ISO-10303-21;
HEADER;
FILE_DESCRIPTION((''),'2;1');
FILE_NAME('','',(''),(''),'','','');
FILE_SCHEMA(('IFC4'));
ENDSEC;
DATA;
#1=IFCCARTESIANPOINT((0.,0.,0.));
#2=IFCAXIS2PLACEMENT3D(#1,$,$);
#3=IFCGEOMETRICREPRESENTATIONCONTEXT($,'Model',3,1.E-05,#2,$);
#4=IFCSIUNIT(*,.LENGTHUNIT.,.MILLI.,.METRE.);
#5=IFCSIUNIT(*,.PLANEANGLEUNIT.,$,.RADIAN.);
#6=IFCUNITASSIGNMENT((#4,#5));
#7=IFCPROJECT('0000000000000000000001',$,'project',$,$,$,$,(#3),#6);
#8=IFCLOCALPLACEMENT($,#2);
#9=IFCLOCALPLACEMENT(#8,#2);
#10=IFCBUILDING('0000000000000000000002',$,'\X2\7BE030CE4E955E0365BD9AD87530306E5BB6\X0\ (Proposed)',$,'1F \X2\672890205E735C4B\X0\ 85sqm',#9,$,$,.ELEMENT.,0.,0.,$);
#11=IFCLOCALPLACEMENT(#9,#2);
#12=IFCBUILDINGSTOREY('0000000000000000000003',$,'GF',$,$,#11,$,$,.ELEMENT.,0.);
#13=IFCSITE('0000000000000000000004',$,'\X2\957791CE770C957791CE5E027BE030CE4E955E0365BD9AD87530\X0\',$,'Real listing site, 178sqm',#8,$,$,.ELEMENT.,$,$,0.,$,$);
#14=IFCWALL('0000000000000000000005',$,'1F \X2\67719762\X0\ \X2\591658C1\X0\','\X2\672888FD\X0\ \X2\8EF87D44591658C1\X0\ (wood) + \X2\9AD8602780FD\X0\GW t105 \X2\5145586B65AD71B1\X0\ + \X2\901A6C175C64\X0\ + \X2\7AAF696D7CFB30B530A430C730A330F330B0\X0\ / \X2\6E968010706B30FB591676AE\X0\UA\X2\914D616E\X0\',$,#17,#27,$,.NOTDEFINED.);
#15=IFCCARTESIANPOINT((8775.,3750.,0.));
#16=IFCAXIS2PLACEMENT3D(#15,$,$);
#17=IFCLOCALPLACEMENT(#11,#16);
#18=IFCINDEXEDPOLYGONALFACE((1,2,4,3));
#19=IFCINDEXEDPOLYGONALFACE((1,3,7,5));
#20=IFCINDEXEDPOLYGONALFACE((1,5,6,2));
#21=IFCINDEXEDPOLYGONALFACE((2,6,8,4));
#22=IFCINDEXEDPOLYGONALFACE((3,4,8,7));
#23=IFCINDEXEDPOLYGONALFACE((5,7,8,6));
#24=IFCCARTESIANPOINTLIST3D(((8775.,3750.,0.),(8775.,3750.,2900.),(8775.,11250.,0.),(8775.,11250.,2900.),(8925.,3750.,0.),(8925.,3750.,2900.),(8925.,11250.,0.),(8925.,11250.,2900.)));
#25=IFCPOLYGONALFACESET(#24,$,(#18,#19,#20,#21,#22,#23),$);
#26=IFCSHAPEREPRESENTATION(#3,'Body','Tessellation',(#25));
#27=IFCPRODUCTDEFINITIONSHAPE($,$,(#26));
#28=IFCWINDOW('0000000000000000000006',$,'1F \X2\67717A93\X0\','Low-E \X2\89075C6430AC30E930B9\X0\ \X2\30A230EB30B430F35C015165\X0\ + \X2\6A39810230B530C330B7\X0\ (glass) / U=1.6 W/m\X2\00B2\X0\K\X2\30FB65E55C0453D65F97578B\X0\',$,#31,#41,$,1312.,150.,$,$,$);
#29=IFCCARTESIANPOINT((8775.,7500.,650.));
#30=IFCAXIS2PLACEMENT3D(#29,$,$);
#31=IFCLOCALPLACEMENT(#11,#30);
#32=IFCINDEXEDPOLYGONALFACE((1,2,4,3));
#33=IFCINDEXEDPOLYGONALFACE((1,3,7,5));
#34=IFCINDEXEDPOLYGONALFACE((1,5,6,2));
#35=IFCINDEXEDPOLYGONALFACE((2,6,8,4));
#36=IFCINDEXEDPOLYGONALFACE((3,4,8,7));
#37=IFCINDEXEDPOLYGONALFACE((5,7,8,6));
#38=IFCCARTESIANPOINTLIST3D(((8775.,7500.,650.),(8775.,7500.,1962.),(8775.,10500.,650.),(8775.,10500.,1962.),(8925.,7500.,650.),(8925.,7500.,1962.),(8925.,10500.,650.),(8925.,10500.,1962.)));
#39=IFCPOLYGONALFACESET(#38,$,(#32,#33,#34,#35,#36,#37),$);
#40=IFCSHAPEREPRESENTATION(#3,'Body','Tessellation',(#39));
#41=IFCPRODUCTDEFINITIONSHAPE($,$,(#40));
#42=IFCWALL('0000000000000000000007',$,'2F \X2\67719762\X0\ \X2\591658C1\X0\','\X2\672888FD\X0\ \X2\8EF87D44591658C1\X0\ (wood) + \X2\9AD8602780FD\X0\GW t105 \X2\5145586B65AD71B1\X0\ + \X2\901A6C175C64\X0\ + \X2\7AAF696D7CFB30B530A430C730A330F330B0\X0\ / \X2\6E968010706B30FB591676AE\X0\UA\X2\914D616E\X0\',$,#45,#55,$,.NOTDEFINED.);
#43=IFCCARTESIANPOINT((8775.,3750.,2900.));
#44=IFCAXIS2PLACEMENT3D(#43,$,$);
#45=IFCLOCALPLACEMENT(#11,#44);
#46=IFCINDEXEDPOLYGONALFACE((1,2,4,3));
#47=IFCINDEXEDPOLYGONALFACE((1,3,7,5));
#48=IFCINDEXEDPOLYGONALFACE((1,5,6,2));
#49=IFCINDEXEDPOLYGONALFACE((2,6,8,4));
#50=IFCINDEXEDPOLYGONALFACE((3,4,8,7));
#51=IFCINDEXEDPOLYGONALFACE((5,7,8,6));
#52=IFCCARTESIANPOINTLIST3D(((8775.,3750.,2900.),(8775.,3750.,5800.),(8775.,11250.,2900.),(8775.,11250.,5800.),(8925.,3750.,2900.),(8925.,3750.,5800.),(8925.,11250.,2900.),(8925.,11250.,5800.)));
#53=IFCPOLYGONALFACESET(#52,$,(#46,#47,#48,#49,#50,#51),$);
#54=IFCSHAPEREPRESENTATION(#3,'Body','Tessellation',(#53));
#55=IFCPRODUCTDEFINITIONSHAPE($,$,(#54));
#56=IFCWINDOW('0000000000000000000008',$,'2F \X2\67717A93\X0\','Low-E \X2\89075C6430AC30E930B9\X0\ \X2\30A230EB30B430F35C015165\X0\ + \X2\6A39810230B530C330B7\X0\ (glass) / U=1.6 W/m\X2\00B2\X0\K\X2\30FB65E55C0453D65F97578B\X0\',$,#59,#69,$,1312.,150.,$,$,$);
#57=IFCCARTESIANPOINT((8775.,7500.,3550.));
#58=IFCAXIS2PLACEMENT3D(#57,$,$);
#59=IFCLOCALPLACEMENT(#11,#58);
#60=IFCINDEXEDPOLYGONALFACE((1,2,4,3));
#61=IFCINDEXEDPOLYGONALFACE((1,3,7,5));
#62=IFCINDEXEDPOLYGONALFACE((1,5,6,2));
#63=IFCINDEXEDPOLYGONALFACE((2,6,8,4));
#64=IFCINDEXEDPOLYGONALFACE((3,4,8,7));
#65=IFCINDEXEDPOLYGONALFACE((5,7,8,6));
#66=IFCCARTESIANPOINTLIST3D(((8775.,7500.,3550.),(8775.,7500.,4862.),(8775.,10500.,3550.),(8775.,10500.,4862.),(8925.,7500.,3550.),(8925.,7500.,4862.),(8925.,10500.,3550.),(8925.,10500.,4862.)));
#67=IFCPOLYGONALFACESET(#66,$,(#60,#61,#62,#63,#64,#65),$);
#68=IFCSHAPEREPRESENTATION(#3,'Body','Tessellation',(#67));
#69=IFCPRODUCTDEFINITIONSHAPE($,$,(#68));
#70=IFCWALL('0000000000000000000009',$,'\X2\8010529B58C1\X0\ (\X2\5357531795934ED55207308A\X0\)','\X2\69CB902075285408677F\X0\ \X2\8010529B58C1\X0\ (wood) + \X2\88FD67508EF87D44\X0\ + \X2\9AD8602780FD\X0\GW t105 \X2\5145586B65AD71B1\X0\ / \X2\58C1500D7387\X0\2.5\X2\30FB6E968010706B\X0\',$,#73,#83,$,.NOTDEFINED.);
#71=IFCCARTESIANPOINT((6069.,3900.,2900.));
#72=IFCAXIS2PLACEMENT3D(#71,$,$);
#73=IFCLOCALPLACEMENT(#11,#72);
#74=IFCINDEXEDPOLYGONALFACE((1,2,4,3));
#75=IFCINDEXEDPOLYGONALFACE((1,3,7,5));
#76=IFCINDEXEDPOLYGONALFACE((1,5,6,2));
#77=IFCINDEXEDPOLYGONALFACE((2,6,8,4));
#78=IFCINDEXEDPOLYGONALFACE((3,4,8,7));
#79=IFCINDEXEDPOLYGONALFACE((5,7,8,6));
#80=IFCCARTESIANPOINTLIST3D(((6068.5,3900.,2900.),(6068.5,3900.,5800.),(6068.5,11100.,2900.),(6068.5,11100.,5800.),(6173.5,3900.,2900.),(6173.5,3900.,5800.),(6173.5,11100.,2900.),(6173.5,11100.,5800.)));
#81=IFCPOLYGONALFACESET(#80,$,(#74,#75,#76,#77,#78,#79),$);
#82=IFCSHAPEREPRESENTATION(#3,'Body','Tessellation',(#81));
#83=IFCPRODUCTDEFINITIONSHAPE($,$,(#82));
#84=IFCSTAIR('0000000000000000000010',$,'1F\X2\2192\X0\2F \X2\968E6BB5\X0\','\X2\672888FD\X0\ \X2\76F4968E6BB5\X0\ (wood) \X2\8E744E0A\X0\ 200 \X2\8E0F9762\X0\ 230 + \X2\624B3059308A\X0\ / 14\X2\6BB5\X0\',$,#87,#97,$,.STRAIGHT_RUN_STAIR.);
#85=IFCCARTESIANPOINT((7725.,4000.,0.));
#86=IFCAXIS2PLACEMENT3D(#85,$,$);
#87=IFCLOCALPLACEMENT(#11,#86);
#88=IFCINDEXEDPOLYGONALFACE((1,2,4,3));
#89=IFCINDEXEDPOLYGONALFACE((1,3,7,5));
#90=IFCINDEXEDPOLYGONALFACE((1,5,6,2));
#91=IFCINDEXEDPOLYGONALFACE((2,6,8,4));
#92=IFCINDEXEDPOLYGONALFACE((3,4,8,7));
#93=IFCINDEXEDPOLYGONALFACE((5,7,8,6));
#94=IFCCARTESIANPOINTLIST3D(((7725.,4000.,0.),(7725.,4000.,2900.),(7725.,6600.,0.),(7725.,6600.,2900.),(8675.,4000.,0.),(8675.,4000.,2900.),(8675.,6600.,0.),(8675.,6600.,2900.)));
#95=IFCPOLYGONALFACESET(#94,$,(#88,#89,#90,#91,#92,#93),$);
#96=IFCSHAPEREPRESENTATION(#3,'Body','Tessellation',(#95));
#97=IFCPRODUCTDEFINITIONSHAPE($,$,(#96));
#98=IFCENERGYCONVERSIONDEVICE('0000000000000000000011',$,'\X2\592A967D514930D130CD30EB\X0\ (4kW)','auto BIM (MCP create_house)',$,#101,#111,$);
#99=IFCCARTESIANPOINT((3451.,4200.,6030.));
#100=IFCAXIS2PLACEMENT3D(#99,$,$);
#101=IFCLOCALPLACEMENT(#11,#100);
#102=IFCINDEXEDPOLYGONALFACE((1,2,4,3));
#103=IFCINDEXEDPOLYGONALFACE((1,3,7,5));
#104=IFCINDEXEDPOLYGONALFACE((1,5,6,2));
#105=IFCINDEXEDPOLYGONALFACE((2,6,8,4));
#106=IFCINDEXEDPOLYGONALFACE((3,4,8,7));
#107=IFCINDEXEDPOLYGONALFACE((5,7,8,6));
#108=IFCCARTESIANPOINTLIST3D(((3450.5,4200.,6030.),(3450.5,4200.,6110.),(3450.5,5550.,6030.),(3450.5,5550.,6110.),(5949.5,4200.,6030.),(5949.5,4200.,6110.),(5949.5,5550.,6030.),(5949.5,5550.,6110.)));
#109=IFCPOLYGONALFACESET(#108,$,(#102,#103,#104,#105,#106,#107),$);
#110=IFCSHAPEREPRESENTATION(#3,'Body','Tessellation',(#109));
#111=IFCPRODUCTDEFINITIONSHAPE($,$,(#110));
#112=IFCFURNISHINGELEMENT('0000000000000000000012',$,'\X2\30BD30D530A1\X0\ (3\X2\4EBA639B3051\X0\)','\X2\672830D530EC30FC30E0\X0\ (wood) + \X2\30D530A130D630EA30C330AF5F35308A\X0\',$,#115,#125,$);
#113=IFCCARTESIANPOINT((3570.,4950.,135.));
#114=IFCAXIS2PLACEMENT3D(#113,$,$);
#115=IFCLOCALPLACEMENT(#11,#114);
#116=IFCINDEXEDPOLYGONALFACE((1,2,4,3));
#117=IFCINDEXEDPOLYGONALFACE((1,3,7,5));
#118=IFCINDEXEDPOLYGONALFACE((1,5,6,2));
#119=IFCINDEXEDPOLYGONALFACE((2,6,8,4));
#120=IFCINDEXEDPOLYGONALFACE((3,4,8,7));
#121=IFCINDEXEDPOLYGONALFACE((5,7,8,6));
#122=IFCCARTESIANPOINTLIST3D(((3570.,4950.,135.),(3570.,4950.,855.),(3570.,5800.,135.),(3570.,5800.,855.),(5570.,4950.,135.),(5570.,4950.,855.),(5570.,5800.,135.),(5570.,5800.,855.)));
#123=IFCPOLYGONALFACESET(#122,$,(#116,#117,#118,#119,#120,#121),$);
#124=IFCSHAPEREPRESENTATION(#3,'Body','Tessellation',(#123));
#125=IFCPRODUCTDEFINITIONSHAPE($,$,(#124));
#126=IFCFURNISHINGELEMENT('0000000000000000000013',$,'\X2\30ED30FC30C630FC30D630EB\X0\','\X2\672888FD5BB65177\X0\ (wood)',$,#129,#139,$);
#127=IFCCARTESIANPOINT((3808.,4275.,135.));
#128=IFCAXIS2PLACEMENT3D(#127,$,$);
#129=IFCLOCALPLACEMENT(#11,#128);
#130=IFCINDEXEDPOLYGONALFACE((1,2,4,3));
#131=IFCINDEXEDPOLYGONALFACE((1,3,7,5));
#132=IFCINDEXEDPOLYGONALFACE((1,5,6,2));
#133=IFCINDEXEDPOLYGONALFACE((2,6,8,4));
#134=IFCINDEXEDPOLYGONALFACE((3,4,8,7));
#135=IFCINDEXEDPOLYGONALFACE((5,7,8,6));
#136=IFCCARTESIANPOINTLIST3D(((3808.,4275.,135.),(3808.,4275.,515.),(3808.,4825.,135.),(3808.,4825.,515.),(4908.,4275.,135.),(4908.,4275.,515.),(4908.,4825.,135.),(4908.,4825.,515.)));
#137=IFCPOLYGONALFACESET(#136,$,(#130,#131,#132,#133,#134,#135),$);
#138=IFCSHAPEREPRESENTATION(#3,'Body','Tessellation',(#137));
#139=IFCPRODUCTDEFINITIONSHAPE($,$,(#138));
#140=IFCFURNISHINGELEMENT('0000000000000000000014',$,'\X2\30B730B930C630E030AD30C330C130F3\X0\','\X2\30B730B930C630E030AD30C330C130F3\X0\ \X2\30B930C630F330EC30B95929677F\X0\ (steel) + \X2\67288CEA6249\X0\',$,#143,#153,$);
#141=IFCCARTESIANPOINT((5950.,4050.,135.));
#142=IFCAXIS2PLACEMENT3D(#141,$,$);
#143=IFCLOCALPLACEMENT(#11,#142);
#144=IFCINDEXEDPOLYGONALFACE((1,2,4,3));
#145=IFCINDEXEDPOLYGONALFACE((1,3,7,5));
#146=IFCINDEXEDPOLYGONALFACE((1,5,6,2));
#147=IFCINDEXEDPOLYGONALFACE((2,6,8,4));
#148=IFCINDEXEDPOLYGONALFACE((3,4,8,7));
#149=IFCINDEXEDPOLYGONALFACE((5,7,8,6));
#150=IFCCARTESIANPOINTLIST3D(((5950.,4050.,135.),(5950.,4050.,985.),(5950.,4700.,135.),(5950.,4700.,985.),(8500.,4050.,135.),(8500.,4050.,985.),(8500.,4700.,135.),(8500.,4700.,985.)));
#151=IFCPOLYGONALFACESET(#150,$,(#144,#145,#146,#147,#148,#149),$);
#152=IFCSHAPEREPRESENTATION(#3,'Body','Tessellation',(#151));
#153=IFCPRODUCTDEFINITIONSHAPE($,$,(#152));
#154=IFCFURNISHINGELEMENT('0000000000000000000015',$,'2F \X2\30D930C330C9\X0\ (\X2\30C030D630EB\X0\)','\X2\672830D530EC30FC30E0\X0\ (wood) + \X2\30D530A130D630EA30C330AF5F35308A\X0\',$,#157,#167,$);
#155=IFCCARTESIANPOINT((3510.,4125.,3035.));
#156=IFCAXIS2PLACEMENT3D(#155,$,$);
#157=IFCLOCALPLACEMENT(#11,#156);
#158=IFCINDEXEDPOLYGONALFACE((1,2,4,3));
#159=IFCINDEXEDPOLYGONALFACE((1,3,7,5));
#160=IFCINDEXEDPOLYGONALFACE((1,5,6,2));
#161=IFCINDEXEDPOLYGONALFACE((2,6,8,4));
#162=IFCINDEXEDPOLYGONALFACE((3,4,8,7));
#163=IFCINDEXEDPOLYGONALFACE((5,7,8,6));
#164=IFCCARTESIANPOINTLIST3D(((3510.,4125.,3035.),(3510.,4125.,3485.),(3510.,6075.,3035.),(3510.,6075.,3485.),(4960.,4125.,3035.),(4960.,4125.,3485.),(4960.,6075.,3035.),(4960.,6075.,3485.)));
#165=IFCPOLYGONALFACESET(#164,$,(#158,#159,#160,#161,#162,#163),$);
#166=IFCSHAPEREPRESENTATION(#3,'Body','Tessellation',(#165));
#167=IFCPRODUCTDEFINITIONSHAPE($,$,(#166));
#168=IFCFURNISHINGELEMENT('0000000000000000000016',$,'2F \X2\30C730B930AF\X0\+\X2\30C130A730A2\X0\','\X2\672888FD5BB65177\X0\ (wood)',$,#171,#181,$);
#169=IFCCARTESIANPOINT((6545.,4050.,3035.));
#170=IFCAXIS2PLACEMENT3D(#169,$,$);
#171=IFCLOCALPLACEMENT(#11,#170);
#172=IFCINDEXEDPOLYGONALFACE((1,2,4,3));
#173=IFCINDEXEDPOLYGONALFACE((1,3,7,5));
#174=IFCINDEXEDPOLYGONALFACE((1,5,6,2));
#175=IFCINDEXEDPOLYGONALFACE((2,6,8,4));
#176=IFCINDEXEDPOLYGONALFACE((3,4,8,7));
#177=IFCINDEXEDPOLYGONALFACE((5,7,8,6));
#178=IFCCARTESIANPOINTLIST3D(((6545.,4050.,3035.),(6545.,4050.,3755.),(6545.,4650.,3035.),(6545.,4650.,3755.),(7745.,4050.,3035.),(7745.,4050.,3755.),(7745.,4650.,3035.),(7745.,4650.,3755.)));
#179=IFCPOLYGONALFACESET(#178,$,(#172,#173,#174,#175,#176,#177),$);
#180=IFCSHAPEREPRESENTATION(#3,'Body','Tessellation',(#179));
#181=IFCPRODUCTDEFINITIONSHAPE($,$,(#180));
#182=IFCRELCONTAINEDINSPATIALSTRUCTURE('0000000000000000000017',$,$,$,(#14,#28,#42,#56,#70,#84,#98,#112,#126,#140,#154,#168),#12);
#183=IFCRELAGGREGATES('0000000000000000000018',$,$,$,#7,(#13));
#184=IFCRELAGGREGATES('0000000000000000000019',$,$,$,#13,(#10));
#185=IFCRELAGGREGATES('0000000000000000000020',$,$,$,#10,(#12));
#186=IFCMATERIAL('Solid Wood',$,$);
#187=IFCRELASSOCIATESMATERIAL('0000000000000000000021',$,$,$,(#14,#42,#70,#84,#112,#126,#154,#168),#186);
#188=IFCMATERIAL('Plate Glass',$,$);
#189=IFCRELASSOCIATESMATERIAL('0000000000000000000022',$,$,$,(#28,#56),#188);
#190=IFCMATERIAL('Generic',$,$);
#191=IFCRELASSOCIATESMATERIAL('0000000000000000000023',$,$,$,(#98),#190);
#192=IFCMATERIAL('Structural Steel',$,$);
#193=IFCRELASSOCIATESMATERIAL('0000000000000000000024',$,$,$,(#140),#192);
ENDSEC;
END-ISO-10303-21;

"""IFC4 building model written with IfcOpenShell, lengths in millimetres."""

from ifc_helpers import new_model, si_unit, frame, frame_2d, origin, place, context, project, spatial, rectangle, extrude, material, element, fill, save


model = new_model("IFC4")

# Units and contexts
model_context = context("Model", 3, precision=1e-05, world=origin())
ifc_project = project(units=[si_unit("LENGTHUNIT", "METRE", prefix="MILLI"), si_unit("PLANEANGLEUNIT", "RADIAN")], contexts=[model_context])

# Site, building, storey
site_placement = place(None, origin())
site = spatial("IfcSite", under=ifc_project, at=site_placement, Name="長野県長野市篠ノ井布施高田", ObjectType="Real listing site, 178sqm", CompositionType="ELEMENT", RefElevation=0.0)
building_placement = place(site_placement, origin())
building = spatial("IfcBuilding", under=site, at=building_placement, Name="篠ノ井布施高田の家 (Proposed)", ObjectType="1F 木造平屋 85sqm", CompositionType="ELEMENT", ElevationOfRefHeight=0.0, ElevationOfTerrain=0.0)
storey_placement = place(building_placement, origin())
storey = spatial("IfcBuildingStorey", under=building, at=storey_placement, Name="GF", CompositionType="ELEMENT", Elevation=0.0)

# Wall, opening, window
ifc_material_1 = material(Name="Solid Wood")
wall_1_placement = place(storey_placement, frame((8775.0, 3750.0, 0.0)))
wall_1 = element("IfcWall", 1, at=wall_1_placement, inside=storey, material=ifc_material_1, Name="1F 東面 外壁", Description="木製 軸組外壁 (wood) + 高性能GW t105 充填断熱 + 通気層 + 窯業系サイディング / 準耐火・外皮UA配慮", PredefinedType="NOTDEFINED", context=model_context, shape_type="SweptSolid", body=[
    extrude(rectangle(XDim=150.0, YDim=7500.0, at=frame_2d((75.0, 3750.0))), frame((8775.0, 3750.0, 0.0)), (0.0, 0.0, 1.0), 2900.0),
])
opening_1_placement = place(storey_placement, frame((8775.0, 7500.0, 650.0)))
opening_1 = element("IfcOpeningElement", 2, at=opening_1_placement, cuts=wall_1, PredefinedType="NOTDEFINED", context=model_context, shape_type="SweptSolid", body=[
    extrude(rectangle(XDim=150.0, YDim=3000.0, at=frame_2d((75.0, 1500.0))), frame((8775.0, 7500.0, 650.0)), (0.0, 0.0, 1.0), 1312.0),
])
ifc_material_2 = material(Name="Plate Glass")
window_1_placement = place(storey_placement, frame((8775.0, 7500.0, 650.0)))
window_1 = element("IfcWindow", 3, at=window_1_placement, inside=storey, material=ifc_material_2, Name="1F 東窓", Description="Low-E 複層ガラス アルゴン封入 + 樹脂サッシ (glass) / U=1.6 W/m²K・日射取得型", OverallHeight=1312.0, OverallWidth=150.0, context=model_context, shape_type="SweptSolid", body=[
    extrude(rectangle(XDim=150.0, YDim=3000.0, at=frame_2d((75.0, 1500.0))), frame((8775.0, 7500.0, 650.0)), (0.0, 0.0, 1.0), 1312.0),
])
fill(opening_1, window_1)

# Wall, opening, window
wall_2_placement = place(storey_placement, frame((8775.0, 3750.0, 2900.0)))
wall_2 = element("IfcWall", 4, at=wall_2_placement, inside=storey, material=ifc_material_1, Name="2F 東面 外壁", Description="木製 軸組外壁 (wood) + 高性能GW t105 充填断熱 + 通気層 + 窯業系サイディング / 準耐火・外皮UA配慮", PredefinedType="NOTDEFINED", context=model_context, shape_type="SweptSolid", body=[
    extrude(rectangle(XDim=150.0, YDim=7500.0, at=frame_2d((75.0, 3750.0))), frame((8775.0, 3750.0, 2900.0)), (0.0, 0.0, 1.0), 2900.0),
])
opening_2_placement = place(storey_placement, frame((8775.0, 7500.0, 3550.0)))
opening_2 = element("IfcOpeningElement", 5, at=opening_2_placement, cuts=wall_2, PredefinedType="NOTDEFINED", context=model_context, shape_type="SweptSolid", body=[
    extrude(rectangle(XDim=150.0, YDim=3000.0, at=frame_2d((75.0, 1500.0))), frame((8775.0, 7500.0, 3550.0)), (0.0, 0.0, 1.0), 1312.0),
])
window_2_placement = place(storey_placement, frame((8775.0, 7500.0, 3550.0)))
window_2 = element("IfcWindow", 6, at=window_2_placement, inside=storey, material=ifc_material_2, Name="2F 東窓", Description="Low-E 複層ガラス アルゴン封入 + 樹脂サッシ (glass) / U=1.6 W/m²K・日射取得型", OverallHeight=1312.0, OverallWidth=150.0, context=model_context, shape_type="SweptSolid", body=[
    extrude(rectangle(XDim=150.0, YDim=3000.0, at=frame_2d((75.0, 1500.0))), frame((8775.0, 7500.0, 3550.0)), (0.0, 0.0, 1.0), 1312.0),
])
fill(opening_2, window_2)

# Wall
wall_3_placement = place(storey_placement, frame((6069.0, 3900.0, 2900.0)))
element("IfcWall", 7, at=wall_3_placement, inside=storey, material=ifc_material_1, Name="耐力壁 (南北間仕切り)", Description="構造用合板 耐力壁 (wood) + 製材軸組 + 高性能GW t105 充填断熱 / 壁倍率2.5・準耐火", PredefinedType="NOTDEFINED", context=model_context, shape_type="SweptSolid", body=[
    extrude(rectangle(XDim=105.0, YDim=7200.0, at=frame_2d((52.0, 3600.0))), frame((6069.0, 3900.0, 2900.0)), (0.0, 0.0, 1.0), 2900.0),
])

# Stair
stair_placement = place(storey_placement, frame((7725.0, 4000.0, 0.0)))
element("IfcStair", 8, at=stair_placement, inside=storey, material=ifc_material_1, Name="1F→2F 階段", Description="木製 直階段 (wood) 蹴上 200 踏面 230 + 手すり / 14段", PredefinedType="STRAIGHT_RUN_STAIR", context=model_context, shape_type="SweptSolid", body=[
    extrude(rectangle(XDim=950.0, YDim=2600.0, at=frame_2d((475.0, 1300.0))), frame((7725.0, 4000.0, 0.0)), (0.0, 0.0, 1.0), 2900.0),
])

# Energy conversion device
ifc_material_3 = material(Name="Generic")
energy_conversion_device_placement = place(storey_placement, frame((3451.0, 4200.0, 6030.0)))
element("IfcEnergyConversionDevice", 9, at=energy_conversion_device_placement, inside=storey, material=ifc_material_3, Name="太陽光パネル (4kW)", Description="auto BIM (MCP create_house)", context=model_context, shape_type="SweptSolid", body=[
    extrude(rectangle(XDim=2499.0, YDim=1350.0, at=frame_2d((1249.0, 675.0))), frame((3451.0, 4200.0, 6030.0)), (0.0, 0.0, 1.0), 80.0),
])

# Furnishing elements
furnishing_1_placement = place(storey_placement, frame((3570.0, 4950.0, 135.0)))
element("IfcFurnishingElement", 10, at=furnishing_1_placement, inside=storey, material=ifc_material_1, Name="ソファ (3人掛け)", Description="木フレーム (wood) + ファブリック張り", context=model_context, shape_type="SweptSolid", body=[
    extrude(rectangle(XDim=2000.0, YDim=850.0, at=frame_2d((1000.0, 425.0))), frame((3570.0, 4950.0, 135.0)), (0.0, 0.0, 1.0), 720.0),
])
furnishing_2_placement = place(storey_placement, frame((3808.0, 4275.0, 135.0)))
element("IfcFurnishingElement", 11, at=furnishing_2_placement, inside=storey, material=ifc_material_1, Name="ローテーブル", Description="木製家具 (wood)", context=model_context, shape_type="SweptSolid", body=[
    extrude(rectangle(XDim=1100.0, YDim=550.0, at=frame_2d((550.0, 275.0))), frame((3808.0, 4275.0, 135.0)), (0.0, 0.0, 1.0), 380.0),
])
ifc_material_4 = material(Name="Structural Steel")
furnishing_3_placement = place(storey_placement, frame((5950.0, 4050.0, 135.0)))
element("IfcFurnishingElement", 12, at=furnishing_3_placement, inside=storey, material=ifc_material_4, Name="システムキッチン", Description="システムキッチン ステンレス天板 (steel) + 木質扉", context=model_context, shape_type="SweptSolid", body=[
    extrude(rectangle(XDim=2550.0, YDim=650.0, at=frame_2d((1275.0, 325.0))), frame((5950.0, 4050.0, 135.0)), (0.0, 0.0, 1.0), 850.0),
])
furnishing_4_placement = place(storey_placement, frame((3510.0, 4125.0, 3035.0)))
element("IfcFurnishingElement", 13, at=furnishing_4_placement, inside=storey, material=ifc_material_1, Name="2F ベッド (ダブル)", Description="木フレーム (wood) + ファブリック張り", context=model_context, shape_type="SweptSolid", body=[
    extrude(rectangle(XDim=1450.0, YDim=1950.0, at=frame_2d((725.0, 975.0))), frame((3510.0, 4125.0, 3035.0)), (0.0, 0.0, 1.0), 450.0),
])
furnishing_5_placement = place(storey_placement, frame((6545.0, 4050.0, 3035.0)))
element("IfcFurnishingElement", 14, at=furnishing_5_placement, inside=storey, material=ifc_material_1, Name="2F デスク+チェア", Description="木製家具 (wood)", context=model_context, shape_type="SweptSolid", body=[
    extrude(rectangle(XDim=1200.0, YDim=600.0, at=frame_2d((600.0, 300.0))), frame((6545.0, 4050.0, 3035.0)), (0.0, 0.0, 1.0), 720.0),
])

save(model, "model.ifc")
